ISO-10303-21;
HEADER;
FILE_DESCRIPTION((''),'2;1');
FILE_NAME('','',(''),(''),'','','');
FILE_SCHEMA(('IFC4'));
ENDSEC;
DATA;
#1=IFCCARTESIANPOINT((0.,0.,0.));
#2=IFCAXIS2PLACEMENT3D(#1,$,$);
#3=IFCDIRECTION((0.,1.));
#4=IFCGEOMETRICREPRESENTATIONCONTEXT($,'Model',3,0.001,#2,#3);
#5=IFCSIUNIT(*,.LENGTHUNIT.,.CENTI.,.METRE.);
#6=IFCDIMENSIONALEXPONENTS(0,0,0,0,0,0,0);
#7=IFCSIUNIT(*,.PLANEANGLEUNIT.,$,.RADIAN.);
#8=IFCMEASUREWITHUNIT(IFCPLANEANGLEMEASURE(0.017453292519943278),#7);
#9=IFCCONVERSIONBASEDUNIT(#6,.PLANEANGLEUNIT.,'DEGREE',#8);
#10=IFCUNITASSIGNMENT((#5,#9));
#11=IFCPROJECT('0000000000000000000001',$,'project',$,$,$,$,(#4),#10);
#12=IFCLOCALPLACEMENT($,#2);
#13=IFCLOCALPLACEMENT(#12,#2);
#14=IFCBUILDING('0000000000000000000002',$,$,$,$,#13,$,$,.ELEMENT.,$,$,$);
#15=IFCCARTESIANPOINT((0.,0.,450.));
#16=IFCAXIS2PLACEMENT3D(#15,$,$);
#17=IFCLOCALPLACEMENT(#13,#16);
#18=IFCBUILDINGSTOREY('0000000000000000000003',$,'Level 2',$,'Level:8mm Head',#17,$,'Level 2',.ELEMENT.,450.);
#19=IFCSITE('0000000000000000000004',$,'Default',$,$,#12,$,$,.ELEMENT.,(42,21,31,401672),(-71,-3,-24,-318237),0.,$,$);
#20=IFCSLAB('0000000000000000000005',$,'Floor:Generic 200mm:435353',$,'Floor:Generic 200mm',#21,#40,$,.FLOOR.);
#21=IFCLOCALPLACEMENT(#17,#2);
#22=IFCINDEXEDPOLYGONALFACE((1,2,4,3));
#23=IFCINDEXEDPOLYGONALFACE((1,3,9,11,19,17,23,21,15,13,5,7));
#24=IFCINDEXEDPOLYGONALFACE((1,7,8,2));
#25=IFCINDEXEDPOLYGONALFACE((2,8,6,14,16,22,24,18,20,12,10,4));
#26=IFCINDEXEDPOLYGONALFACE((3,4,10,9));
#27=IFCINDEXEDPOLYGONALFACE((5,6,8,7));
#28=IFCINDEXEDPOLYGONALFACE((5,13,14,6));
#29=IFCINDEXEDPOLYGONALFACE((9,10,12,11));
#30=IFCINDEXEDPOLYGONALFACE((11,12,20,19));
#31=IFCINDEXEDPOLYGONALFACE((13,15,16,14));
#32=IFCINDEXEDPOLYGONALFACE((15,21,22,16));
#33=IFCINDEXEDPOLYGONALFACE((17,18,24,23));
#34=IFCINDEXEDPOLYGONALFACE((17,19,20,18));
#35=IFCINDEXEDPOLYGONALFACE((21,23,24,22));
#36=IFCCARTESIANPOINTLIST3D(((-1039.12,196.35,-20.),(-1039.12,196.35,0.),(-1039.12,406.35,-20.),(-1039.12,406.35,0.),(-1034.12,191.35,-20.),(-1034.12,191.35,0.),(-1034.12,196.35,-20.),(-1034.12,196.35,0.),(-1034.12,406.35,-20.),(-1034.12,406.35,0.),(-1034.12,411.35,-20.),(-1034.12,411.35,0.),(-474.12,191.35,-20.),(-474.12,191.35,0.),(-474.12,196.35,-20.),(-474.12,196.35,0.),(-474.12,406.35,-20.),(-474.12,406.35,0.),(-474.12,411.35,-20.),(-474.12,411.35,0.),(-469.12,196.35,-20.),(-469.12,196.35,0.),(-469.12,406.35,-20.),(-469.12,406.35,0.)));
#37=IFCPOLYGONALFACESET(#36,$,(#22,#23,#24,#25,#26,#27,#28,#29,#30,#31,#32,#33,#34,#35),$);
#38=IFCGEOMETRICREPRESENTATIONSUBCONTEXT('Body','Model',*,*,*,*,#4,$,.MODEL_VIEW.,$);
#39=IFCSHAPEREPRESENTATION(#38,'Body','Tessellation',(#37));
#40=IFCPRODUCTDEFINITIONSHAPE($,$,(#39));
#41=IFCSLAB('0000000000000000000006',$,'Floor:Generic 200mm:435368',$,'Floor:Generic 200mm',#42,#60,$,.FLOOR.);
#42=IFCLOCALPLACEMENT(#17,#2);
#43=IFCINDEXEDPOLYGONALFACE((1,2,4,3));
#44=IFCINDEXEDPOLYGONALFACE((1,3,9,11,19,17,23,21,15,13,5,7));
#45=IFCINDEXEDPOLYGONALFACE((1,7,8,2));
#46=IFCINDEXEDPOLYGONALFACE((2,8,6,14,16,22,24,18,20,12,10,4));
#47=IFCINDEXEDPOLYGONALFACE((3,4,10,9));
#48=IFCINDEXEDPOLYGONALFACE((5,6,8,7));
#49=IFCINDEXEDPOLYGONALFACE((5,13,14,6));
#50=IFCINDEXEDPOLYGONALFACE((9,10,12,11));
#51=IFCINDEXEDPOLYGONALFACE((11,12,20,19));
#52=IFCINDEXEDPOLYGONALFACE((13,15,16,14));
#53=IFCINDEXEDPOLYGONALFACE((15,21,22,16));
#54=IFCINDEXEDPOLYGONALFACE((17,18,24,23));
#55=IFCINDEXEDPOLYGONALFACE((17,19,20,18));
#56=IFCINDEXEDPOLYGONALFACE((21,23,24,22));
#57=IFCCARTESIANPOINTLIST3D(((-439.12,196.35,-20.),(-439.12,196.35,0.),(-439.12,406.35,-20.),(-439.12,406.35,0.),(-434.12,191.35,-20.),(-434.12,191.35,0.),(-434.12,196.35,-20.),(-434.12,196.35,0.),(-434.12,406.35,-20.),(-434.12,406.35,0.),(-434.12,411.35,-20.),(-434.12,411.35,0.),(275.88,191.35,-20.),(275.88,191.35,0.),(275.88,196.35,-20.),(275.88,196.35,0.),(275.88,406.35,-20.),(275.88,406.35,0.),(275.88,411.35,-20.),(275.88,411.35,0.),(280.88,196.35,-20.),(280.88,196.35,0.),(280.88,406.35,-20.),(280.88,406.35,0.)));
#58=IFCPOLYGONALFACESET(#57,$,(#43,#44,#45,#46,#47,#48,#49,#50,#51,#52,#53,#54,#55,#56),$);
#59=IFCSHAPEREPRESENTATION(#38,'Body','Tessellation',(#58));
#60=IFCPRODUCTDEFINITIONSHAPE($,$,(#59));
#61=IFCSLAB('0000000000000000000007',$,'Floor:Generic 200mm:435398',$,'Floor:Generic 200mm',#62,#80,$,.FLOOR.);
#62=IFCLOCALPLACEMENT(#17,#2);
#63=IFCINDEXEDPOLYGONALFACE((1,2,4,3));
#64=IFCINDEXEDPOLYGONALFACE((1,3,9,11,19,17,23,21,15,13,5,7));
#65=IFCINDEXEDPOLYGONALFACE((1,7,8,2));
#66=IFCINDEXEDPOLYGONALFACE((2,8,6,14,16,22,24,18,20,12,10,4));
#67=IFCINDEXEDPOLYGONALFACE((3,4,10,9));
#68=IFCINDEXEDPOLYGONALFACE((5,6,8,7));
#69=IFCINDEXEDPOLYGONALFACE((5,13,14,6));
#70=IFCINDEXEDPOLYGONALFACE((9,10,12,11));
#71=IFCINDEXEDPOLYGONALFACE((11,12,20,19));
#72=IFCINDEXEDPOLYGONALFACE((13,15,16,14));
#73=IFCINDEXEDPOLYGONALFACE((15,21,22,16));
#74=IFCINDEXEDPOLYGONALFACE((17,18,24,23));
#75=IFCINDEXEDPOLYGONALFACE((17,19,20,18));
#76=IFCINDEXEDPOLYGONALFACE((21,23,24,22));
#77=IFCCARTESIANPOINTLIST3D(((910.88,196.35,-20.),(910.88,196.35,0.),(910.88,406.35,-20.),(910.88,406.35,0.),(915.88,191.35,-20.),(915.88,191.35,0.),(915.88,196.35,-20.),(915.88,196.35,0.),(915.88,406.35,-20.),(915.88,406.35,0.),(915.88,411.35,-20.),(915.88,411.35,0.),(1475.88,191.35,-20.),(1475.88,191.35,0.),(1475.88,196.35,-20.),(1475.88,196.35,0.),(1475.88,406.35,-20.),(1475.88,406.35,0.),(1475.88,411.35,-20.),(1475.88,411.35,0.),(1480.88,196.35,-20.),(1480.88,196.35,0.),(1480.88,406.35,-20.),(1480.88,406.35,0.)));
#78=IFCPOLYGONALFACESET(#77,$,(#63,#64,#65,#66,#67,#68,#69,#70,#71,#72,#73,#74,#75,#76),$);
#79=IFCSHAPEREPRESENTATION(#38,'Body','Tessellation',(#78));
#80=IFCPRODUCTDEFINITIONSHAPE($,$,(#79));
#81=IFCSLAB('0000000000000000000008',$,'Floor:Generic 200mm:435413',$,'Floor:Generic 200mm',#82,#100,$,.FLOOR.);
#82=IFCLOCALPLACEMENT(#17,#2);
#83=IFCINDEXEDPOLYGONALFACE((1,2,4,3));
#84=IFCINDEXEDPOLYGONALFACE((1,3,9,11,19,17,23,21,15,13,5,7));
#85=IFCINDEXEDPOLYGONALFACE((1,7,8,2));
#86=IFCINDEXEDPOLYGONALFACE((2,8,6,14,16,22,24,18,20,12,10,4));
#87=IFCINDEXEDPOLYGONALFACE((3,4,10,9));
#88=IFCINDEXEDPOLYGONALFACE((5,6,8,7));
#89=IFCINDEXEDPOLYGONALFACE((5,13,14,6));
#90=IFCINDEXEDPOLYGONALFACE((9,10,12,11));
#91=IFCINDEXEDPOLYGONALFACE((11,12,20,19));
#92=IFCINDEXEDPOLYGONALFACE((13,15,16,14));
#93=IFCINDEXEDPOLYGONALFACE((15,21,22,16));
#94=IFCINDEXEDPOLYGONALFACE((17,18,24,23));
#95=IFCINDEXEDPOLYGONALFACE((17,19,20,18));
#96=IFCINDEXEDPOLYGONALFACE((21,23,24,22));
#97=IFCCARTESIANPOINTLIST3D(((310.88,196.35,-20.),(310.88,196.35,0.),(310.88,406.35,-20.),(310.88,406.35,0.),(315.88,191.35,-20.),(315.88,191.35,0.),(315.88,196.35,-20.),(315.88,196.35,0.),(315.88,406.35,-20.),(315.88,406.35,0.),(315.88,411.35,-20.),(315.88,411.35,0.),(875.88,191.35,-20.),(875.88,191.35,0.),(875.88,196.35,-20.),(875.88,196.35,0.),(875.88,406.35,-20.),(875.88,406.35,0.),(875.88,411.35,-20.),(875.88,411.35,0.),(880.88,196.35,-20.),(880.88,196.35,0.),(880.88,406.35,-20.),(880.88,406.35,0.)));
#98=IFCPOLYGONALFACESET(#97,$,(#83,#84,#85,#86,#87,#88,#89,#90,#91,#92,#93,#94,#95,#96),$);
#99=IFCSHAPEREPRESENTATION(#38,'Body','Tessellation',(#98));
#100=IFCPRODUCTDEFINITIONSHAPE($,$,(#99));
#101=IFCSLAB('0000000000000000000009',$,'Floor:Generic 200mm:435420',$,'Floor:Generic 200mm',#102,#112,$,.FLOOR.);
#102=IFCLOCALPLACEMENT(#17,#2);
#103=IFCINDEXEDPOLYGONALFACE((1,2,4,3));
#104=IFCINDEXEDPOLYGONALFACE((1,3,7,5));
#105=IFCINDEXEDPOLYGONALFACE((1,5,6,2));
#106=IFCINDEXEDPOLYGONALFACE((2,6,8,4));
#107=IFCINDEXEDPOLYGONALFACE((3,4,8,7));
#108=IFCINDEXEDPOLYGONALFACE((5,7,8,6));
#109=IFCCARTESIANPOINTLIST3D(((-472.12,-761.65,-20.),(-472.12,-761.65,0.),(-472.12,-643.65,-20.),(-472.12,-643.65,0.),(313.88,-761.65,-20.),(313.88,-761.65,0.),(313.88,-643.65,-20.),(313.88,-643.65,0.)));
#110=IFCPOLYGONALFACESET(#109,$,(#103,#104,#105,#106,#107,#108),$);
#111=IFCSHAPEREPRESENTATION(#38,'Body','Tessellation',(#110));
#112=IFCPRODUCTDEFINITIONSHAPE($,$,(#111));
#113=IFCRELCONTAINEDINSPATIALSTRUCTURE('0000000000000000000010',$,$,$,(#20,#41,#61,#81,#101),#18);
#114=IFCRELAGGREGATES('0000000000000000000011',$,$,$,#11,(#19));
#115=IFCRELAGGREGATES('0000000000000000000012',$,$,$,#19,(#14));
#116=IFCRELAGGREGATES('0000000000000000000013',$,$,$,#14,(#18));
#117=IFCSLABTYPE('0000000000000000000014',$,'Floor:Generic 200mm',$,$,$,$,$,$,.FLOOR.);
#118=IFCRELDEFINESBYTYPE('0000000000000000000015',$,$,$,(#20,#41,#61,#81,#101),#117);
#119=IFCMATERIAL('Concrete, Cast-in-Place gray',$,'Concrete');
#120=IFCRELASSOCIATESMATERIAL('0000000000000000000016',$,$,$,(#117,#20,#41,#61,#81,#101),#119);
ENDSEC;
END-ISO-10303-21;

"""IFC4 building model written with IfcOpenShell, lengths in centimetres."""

from ifc_helpers import new_model, entity, si_unit, converted_unit, direction, frame, origin, place, context, subcontext, project, spatial, indexed_curve, outline, extrude, material, type_object, element, save


model = new_model("IFC4")

# Units and contexts
model_context = context("Model", 3, precision=0.001, world=origin(), true_north=direction((0.0, 1.0)))
body_context = subcontext(model_context, "Body", "Model", "MODEL_VIEW")
ifc_project = project(units=[si_unit("LENGTHUNIT", "METRE", prefix="CENTI"), converted_unit("PLANEANGLEUNIT", "DEGREE", entity("IfcPlaneAngleMeasure", 0.017453292519943278), si_unit("PLANEANGLEUNIT", "RADIAN"), dimensions=[0, 0, 0, 0, 0, 0, 0])], contexts=[model_context])

# Site, building, storey
site_placement = place(None, origin())
site = spatial("IfcSite", under=ifc_project, at=site_placement, Name="Default", CompositionType="ELEMENT", RefLatitude=(42, 21, 31, 401672), RefLongitude=(-71, -3, -24, -318237), RefElevation=0.0)
building_placement = place(site_placement, origin())
building = spatial("IfcBuilding", under=site, at=building_placement, CompositionType="ELEMENT")
storey_placement = place(building_placement, frame((0.0, 0.0, 450.0)))
storey = spatial("IfcBuildingStorey", under=building, at=storey_placement, Name="Level 2", ObjectType="Level:8mm Head", LongName="Level 2", CompositionType="ELEMENT", Elevation=450.0)

# Shared definitions
ifc_material_1 = material(Name="Concrete, Cast-in-Place gray", Category="Concrete")

# Shared definitions
slab_type = type_object("IfcSlabType", Name="Floor:Generic 200mm", PredefinedType="FLOOR", material=ifc_material_1)

# Slabs
slab_1_placement = place(storey_placement, origin())
element("IfcSlab", 1, at=slab_1_placement, inside=storey, type_object=slab_type, material=ifc_material_1, Name="Floor:Generic 200mm:435353", ObjectType="Floor:Generic 200mm", PredefinedType="FLOOR", context=body_context, shape_type="SweptSolid", body=[
    extrude(outline(indexed_curve([(-105.0, -285.0), (105.0, -285.0), (105.0, -280.0), (110.0, -280.0), (110.0, 280.0), (105.0, 280.0), (105.0, 285.0), (-105.0, 285.0), (-105.0, 280.0), (-110.0, 280.0), (-110.0, -280.0), (-105.0, -280.0), (-105.0, -285.0)], self_intersect=False)), frame((-754.12, 301.35, 0.0), z_axis=(0.0, 0.0, -1.0), x_axis=(0.0, 1.0, 0.0)), (0.0, 0.0, 1.0), 20.0),
])
slab_2_placement = place(storey_placement, origin())
element("IfcSlab", 2, at=slab_2_placement, inside=storey, type_object=slab_type, material=ifc_material_1, Name="Floor:Generic 200mm:435368", ObjectType="Floor:Generic 200mm", PredefinedType="FLOOR", context=body_context, shape_type="SweptSolid", body=[
    extrude(outline(indexed_curve([(-105.0, -360.0), (105.0, -360.0), (105.0, -355.0), (110.0, -355.0), (110.0, 355.0), (105.0, 355.0), (105.0, 360.0), (-105.0, 360.0), (-105.0, 355.0), (-110.0, 355.0), (-110.0, -355.0), (-105.0, -355.0), (-105.0, -360.0)], self_intersect=False)), frame((-79.12, 301.35, 0.0), z_axis=(0.0, 0.0, -1.0), x_axis=(0.0, 1.0, 0.0)), (0.0, 0.0, 1.0), 20.0),
])
slab_3_placement = place(storey_placement, origin())
element("IfcSlab", 3, at=slab_3_placement, inside=storey, type_object=slab_type, material=ifc_material_1, Name="Floor:Generic 200mm:435398", ObjectType="Floor:Generic 200mm", PredefinedType="FLOOR", context=body_context, shape_type="SweptSolid", body=[
    extrude(outline(indexed_curve([(-105.0, -285.0), (105.0, -285.0), (105.0, -280.0), (110.0, -280.0), (110.0, 280.0), (105.0, 280.0), (105.0, 285.0), (-105.0, 285.0), (-105.0, 280.0), (-110.0, 280.0), (-110.0, -280.0), (-105.0, -280.0), (-105.0, -285.0)], self_intersect=False)), frame((1195.88, 301.35, 0.0), z_axis=(0.0, 0.0, -1.0), x_axis=(0.0, 1.0, 0.0)), (0.0, 0.0, 1.0), 20.0),
])
slab_4_placement = place(storey_placement, origin())
element("IfcSlab", 4, at=slab_4_placement, inside=storey, type_object=slab_type, material=ifc_material_1, Name="Floor:Generic 200mm:435413", ObjectType="Floor:Generic 200mm", PredefinedType="FLOOR", context=body_context, shape_type="SweptSolid", body=[
    extrude(outline(indexed_curve([(-105.0, -285.0), (105.0, -285.0), (105.0, -280.0), (110.0, -280.0), (110.0, 280.0), (105.0, 280.0), (105.0, 285.0), (-105.0, 285.0), (-105.0, 280.0), (-110.0, 280.0), (-110.0, -280.0), (-105.0, -280.0), (-105.0, -285.0)], self_intersect=False)), frame((595.88, 301.35, 0.0), z_axis=(0.0, 0.0, -1.0), x_axis=(0.0, 1.0, 0.0)), (0.0, 0.0, 1.0), 20.0),
])
slab_5_placement = place(storey_placement, origin())
element("IfcSlab", 5, at=slab_5_placement, inside=storey, type_object=slab_type, material=ifc_material_1, Name="Floor:Generic 200mm:435420", ObjectType="Floor:Generic 200mm", PredefinedType="FLOOR", context=body_context, shape_type="SweptSolid", body=[
    extrude(outline(indexed_curve([(-59.0, -393.0), (59.0, -393.0), (59.0, 393.0), (-59.0, 393.0), (-59.0, -393.0)], self_intersect=False)), frame((-79.12, -702.65, 0.0), z_axis=(0.0, 0.0, -1.0), x_axis=(0.0, 1.0, 0.0)), (0.0, 0.0, 1.0), 20.0),
])

save(model, "model.ifc")
